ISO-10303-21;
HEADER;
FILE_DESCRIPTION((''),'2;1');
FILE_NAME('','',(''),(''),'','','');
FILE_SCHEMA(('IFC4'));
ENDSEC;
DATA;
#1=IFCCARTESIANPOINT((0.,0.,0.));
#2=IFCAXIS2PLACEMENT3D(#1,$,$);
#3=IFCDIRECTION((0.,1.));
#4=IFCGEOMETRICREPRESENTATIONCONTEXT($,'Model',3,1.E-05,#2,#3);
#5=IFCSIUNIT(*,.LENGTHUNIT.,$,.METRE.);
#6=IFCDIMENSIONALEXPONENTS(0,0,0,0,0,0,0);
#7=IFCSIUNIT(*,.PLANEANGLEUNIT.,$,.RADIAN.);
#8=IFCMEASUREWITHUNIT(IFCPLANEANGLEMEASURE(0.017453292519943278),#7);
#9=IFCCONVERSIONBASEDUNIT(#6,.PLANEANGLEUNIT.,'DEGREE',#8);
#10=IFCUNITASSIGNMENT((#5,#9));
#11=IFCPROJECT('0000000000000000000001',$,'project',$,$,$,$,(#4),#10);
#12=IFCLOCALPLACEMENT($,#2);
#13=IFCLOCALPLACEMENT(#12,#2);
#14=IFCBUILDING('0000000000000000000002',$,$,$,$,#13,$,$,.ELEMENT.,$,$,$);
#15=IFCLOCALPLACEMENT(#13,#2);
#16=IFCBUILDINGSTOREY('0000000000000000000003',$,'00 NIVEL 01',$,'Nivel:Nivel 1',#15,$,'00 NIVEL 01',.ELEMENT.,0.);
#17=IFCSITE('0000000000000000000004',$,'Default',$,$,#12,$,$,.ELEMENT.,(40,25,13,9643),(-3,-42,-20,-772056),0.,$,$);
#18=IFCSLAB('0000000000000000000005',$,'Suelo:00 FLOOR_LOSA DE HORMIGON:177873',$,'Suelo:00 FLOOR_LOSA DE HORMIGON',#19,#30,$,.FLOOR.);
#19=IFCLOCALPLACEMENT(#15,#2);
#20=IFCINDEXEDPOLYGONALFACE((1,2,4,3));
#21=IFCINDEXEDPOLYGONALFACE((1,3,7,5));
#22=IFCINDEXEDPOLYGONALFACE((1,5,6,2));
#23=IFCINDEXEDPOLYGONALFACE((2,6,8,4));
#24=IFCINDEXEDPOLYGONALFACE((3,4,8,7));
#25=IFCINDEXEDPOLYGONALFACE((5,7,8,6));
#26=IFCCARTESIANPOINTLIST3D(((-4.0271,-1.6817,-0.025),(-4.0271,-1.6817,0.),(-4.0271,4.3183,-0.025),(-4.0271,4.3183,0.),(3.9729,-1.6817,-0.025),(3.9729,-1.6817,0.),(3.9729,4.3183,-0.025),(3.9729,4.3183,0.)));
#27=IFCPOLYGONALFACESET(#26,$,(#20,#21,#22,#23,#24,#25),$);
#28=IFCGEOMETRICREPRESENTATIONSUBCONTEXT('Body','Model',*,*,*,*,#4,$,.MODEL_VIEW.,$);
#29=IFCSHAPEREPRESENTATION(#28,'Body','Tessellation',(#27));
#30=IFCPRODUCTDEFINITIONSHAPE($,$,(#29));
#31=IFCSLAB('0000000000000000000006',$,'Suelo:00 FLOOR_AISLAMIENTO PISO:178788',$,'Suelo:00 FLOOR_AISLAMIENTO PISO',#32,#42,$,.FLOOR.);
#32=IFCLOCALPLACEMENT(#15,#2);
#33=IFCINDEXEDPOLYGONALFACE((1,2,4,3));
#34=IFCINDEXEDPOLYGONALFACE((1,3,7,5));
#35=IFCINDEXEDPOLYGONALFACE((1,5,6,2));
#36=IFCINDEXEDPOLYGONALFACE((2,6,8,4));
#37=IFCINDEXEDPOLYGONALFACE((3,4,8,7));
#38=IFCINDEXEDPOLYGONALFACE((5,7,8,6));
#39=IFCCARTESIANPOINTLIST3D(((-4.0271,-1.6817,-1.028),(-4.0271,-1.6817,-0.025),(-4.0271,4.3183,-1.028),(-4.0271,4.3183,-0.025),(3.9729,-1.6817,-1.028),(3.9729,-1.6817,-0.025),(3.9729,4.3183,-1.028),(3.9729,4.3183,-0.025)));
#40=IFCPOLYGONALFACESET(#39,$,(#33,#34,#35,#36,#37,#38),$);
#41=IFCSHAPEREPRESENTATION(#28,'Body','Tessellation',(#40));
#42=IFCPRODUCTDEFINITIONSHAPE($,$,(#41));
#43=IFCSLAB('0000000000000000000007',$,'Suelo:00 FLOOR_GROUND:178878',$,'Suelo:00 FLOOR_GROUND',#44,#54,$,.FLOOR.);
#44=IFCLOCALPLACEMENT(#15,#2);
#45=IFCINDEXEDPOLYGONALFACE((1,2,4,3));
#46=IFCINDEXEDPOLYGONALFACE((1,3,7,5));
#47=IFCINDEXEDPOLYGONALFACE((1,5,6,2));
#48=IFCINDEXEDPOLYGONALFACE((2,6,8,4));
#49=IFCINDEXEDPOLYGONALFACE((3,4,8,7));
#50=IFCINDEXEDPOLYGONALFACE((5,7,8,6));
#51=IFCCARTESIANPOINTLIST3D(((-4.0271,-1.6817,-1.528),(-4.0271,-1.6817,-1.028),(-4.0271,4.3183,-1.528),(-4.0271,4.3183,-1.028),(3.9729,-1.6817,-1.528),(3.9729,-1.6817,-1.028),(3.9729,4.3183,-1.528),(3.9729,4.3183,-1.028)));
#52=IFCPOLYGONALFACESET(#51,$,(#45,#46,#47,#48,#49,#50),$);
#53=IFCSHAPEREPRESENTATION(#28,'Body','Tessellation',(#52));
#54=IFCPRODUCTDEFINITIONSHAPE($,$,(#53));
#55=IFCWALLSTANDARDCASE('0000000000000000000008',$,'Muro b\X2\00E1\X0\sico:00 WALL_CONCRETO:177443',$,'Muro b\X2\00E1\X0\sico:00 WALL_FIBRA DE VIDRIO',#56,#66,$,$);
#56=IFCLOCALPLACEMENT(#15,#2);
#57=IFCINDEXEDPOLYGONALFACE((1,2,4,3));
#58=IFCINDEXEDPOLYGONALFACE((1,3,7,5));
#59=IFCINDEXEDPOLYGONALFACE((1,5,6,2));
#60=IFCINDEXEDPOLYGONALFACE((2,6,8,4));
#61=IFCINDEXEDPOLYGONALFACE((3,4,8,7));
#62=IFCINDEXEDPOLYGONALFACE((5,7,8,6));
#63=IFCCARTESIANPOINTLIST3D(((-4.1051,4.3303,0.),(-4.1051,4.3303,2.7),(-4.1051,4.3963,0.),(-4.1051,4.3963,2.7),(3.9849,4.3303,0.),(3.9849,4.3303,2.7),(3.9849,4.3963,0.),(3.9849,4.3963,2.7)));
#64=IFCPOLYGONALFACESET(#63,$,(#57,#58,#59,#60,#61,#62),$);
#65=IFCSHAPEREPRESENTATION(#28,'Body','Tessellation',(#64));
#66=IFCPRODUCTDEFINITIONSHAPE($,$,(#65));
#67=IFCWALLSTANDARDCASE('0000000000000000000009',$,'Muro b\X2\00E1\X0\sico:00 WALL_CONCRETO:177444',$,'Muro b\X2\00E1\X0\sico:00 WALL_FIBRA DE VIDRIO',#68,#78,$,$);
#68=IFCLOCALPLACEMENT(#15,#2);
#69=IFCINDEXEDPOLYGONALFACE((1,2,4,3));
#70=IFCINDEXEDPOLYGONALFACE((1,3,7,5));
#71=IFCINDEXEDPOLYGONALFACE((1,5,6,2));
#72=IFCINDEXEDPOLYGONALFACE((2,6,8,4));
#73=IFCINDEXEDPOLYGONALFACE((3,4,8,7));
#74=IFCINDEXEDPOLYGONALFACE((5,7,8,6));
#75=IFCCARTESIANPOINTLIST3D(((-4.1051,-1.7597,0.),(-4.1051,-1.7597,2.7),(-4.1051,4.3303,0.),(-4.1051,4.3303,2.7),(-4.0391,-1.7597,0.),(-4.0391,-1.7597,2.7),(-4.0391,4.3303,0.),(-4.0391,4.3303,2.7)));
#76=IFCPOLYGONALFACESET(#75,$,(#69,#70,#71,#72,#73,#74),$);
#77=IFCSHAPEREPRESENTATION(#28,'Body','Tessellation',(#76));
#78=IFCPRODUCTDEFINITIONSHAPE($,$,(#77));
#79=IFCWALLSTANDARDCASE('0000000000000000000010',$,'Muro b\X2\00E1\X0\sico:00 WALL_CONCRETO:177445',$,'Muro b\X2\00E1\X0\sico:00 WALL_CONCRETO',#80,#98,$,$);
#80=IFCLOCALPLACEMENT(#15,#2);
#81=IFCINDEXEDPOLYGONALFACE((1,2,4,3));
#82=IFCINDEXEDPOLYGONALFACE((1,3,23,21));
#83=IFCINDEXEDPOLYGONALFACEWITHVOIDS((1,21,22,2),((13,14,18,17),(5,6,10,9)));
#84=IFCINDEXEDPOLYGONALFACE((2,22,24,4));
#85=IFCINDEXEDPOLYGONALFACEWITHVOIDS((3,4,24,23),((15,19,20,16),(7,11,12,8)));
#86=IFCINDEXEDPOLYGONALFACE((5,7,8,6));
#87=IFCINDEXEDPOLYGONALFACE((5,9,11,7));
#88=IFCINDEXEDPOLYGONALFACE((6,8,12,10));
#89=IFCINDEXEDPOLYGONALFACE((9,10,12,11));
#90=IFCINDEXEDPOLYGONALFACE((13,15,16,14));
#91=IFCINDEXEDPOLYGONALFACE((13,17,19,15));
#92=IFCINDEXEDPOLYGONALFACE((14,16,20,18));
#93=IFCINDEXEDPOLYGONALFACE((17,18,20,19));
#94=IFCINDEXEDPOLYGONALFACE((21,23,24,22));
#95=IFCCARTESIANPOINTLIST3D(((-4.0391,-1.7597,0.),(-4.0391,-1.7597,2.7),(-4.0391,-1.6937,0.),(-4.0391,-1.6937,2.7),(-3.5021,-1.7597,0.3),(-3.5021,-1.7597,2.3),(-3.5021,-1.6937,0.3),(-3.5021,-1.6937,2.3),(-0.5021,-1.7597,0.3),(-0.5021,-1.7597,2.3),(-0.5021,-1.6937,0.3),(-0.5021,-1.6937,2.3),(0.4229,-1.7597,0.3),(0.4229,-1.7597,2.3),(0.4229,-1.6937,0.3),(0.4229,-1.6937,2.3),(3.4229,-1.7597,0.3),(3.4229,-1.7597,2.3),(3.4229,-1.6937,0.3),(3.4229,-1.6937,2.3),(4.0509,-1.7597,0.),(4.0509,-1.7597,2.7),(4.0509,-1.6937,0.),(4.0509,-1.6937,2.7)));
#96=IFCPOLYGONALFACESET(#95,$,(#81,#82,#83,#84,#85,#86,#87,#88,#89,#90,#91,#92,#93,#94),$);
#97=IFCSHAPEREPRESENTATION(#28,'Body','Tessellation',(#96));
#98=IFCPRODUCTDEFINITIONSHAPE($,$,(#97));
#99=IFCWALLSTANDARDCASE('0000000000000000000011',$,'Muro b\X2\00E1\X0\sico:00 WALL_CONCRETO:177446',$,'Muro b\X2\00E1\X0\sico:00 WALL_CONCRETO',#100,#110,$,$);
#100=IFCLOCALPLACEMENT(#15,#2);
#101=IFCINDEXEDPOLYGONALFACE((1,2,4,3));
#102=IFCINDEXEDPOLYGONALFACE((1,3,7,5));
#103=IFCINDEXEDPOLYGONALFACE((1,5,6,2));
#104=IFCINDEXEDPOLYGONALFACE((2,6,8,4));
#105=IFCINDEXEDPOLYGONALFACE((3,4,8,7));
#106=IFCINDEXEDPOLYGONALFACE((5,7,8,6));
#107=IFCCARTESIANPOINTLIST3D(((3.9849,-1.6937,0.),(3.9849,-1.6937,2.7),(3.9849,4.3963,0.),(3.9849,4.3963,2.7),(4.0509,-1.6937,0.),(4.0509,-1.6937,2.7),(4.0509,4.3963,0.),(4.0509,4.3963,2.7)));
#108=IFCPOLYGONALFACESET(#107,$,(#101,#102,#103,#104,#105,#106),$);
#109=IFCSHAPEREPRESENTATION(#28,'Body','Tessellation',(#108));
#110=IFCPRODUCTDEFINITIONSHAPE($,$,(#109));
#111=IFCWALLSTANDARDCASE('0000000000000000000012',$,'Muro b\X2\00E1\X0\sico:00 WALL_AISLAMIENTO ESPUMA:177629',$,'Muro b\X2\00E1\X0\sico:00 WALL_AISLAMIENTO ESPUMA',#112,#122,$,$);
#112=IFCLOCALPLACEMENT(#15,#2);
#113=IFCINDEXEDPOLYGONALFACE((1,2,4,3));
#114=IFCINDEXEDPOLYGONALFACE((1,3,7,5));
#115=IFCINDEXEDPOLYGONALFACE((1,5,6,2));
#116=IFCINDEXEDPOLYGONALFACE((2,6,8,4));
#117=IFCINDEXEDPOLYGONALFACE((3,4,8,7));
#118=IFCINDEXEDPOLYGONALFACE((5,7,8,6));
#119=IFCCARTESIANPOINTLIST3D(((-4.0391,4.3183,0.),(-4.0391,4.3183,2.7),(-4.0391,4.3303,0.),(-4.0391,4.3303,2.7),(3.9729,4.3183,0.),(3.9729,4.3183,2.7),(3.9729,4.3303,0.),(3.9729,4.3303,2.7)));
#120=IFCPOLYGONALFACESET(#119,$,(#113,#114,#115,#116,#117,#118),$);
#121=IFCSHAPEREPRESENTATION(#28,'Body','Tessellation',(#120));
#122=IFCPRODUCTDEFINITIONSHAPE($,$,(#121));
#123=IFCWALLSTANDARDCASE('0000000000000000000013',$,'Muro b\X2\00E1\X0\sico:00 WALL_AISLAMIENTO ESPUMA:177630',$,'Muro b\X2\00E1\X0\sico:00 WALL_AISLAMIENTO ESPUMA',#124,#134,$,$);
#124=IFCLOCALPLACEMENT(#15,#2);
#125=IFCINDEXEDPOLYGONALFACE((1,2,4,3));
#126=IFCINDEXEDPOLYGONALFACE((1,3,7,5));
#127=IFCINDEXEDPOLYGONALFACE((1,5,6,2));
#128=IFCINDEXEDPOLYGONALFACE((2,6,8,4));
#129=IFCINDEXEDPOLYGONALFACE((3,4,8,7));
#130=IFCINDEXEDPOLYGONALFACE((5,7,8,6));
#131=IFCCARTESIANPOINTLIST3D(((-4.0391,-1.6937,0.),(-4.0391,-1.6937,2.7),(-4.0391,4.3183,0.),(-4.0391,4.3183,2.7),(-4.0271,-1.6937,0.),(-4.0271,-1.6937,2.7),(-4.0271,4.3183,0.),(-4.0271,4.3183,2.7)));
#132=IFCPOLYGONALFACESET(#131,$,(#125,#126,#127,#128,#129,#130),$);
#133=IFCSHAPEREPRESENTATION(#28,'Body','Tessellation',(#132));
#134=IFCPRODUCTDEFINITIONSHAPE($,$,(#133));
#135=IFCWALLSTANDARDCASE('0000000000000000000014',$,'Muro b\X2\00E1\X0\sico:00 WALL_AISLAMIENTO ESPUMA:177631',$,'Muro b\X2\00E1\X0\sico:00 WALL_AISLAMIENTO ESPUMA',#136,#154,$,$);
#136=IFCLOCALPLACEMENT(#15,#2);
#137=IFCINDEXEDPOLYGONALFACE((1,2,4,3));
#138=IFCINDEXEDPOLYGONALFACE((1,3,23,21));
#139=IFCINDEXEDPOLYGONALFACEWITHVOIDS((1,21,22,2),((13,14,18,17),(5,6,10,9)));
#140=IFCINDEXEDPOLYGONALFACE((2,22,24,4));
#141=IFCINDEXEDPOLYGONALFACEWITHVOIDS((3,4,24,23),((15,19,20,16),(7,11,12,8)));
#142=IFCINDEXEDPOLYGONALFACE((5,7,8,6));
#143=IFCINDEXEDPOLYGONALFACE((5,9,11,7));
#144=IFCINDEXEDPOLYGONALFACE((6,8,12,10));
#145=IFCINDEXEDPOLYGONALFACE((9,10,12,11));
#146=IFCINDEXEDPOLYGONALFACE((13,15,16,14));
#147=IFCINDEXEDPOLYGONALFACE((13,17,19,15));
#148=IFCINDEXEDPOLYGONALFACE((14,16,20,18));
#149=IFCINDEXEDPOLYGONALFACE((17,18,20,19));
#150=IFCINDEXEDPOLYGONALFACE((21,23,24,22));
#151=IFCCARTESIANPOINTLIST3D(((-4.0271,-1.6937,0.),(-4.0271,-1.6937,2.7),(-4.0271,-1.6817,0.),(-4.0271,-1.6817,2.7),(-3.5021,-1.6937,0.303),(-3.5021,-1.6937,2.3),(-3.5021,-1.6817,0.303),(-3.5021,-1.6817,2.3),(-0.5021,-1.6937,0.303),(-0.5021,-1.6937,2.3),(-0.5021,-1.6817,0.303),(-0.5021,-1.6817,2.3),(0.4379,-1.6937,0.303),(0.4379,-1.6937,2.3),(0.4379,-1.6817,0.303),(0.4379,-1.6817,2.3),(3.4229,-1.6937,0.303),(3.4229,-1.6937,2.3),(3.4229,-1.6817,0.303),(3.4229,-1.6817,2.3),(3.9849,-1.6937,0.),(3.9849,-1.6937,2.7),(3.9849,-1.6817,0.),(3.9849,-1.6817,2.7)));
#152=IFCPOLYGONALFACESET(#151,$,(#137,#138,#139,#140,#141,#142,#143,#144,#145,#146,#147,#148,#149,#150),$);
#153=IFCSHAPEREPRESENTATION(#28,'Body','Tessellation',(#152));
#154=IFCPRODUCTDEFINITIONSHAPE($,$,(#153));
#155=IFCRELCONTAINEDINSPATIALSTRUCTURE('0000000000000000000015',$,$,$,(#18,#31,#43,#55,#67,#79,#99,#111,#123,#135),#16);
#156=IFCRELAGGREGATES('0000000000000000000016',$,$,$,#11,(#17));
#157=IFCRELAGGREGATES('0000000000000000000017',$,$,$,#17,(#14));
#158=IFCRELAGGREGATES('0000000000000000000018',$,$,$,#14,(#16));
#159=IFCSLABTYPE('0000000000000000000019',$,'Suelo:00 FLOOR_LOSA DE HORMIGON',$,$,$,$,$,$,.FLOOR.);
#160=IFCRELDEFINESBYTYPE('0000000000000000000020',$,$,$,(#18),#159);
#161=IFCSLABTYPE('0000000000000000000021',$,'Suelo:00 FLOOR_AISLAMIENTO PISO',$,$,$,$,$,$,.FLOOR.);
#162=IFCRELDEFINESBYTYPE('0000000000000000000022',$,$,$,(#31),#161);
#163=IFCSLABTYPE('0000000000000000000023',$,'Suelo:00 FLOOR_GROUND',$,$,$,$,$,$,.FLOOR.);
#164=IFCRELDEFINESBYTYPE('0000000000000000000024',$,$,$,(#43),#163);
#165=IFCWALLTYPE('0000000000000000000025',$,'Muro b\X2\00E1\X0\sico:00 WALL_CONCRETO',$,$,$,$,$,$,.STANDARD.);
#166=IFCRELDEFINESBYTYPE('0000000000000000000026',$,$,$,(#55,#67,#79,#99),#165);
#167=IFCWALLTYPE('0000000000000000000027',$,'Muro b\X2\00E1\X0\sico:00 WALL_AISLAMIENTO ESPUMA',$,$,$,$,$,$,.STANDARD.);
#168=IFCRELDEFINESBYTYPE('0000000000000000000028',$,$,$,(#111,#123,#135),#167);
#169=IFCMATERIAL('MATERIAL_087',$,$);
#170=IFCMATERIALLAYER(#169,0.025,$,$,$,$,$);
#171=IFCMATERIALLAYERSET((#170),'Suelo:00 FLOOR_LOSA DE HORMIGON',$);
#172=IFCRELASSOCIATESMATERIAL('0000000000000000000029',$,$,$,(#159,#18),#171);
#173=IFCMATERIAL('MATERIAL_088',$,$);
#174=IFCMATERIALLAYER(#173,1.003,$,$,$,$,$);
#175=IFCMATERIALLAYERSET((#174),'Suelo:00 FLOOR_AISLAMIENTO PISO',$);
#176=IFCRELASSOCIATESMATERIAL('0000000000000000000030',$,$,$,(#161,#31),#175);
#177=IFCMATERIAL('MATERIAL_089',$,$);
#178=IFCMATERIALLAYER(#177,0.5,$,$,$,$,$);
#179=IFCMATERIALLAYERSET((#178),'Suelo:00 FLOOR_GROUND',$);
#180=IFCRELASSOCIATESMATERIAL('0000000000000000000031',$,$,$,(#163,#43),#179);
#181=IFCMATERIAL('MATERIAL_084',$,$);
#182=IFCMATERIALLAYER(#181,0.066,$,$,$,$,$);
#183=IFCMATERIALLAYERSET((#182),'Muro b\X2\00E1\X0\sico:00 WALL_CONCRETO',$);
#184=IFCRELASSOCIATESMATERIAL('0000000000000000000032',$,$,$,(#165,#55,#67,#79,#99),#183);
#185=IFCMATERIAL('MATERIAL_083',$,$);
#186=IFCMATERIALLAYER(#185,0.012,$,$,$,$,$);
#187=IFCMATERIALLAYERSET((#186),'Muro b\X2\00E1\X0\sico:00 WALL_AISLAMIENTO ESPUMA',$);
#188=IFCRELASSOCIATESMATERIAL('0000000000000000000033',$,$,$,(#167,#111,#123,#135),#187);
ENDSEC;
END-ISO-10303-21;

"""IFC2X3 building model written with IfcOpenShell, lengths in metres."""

from ifc_helpers import new_model, entity, si_unit, converted_unit, direction, frame, frame_2d, origin, origin_2d_with_axis, place, context, subcontext, project, spatial, rectangle, extrude, material, layer, layer_set, layer_usage, type_object, element, save


model = new_model("IFC2X3")

# Units and contexts
model_context = context("Model", 3, precision=1e-05, world=origin(), true_north=direction((0.0, 1.0)))
body_context = subcontext(model_context, "Body", "Model", "MODEL_VIEW")
ifc_project = project(units=[si_unit("LENGTHUNIT", "METRE"), converted_unit("PLANEANGLEUNIT", "DEGREE", entity("IfcPlaneAngleMeasure", 0.017453292519943278), si_unit("PLANEANGLEUNIT", "RADIAN"), dimensions=[0, 0, 0, 0, 0, 0, 0])], contexts=[model_context])

# Site, building, storey
site_placement = place(None, origin())
site = spatial("IfcSite", under=ifc_project, at=site_placement, Name="Default", CompositionType="ELEMENT", RefLatitude=(40, 25, 13, 9643), RefLongitude=(-3, -42, -20, -772056), RefElevation=0.0)
building_placement = place(site_placement, origin())
building = spatial("IfcBuilding", under=site, at=building_placement, CompositionType="ELEMENT")
storey_placement = place(building_placement, origin())
storey = spatial("IfcBuildingStorey", under=building, at=storey_placement, Name="00 NIVEL 01", ObjectType="Nivel:Nivel 1", LongName="00 NIVEL 01", CompositionType="ELEMENT", Elevation=0.0)

# Slabs
ifc_material_1 = material(Name="MATERIAL_087")
ifc_layer_1 = layer(ifc_material_1, 0.025)
ifc_layer_set_1 = layer_set([ifc_layer_1], Name="Suelo:00 FLOOR_LOSA DE HORMIGON")
ifc_layer_usage_1 = layer_usage(ifc_layer_set_1, "AXIS3", "POSITIVE", 0.0)
slab_type_1 = type_object("IfcSlabType", Name="Suelo:00 FLOOR_LOSA DE HORMIGON", PredefinedType="FLOOR", material=ifc_layer_set_1)
slab_1_placement = place(storey_placement, origin())
element("IfcSlab", 1, at=slab_1_placement, inside=storey, type_object=slab_type_1, material=ifc_layer_usage_1, Name="Suelo:00 FLOOR_LOSA DE HORMIGON:177873", ObjectType="Suelo:00 FLOOR_LOSA DE HORMIGON", PredefinedType="FLOOR", context=body_context, shape_type="SweptSolid", body=[
    extrude(rectangle(XDim=6.0, YDim=8.0, at=origin_2d_with_axis()), frame((-0.0271, 1.3183, 0.0), z_axis=(0.0, 0.0, -1.0), x_axis=(0.0, 1.0, 0.0)), (0.0, 0.0, 1.0), 0.025),
])
ifc_material_2 = material(Name="MATERIAL_088")
ifc_layer_2 = layer(ifc_material_2, 1.003)
ifc_layer_set_2 = layer_set([ifc_layer_2], Name="Suelo:00 FLOOR_AISLAMIENTO PISO")
ifc_layer_usage_2 = layer_usage(ifc_layer_set_2, "AXIS3", "POSITIVE", 0.0)
slab_type_2 = type_object("IfcSlabType", Name="Suelo:00 FLOOR_AISLAMIENTO PISO", PredefinedType="FLOOR", material=ifc_layer_set_2)
slab_2_placement = place(storey_placement, origin())
element("IfcSlab", 2, at=slab_2_placement, inside=storey, type_object=slab_type_2, material=ifc_layer_usage_2, Name="Suelo:00 FLOOR_AISLAMIENTO PISO:178788", ObjectType="Suelo:00 FLOOR_AISLAMIENTO PISO", PredefinedType="FLOOR", context=body_context, shape_type="SweptSolid", body=[
    extrude(rectangle(XDim=6.0, YDim=8.0, at=origin_2d_with_axis()), frame((-0.0271, 1.3183, -0.025), z_axis=(0.0, 0.0, -1.0), x_axis=(0.0, 1.0, 0.0)), (0.0, 0.0, 1.0), 1.003),
])
ifc_material_3 = material(Name="MATERIAL_089")
ifc_layer_3 = layer(ifc_material_3, 0.5)
ifc_layer_set_3 = layer_set([ifc_layer_3], Name="Suelo:00 FLOOR_GROUND")
ifc_layer_usage_3 = layer_usage(ifc_layer_set_3, "AXIS3", "POSITIVE", 0.0)
slab_type_3 = type_object("IfcSlabType", Name="Suelo:00 FLOOR_GROUND", PredefinedType="FLOOR", material=ifc_layer_set_3)
slab_3_placement = place(storey_placement, origin())
element("IfcSlab", 3, at=slab_3_placement, inside=storey, type_object=slab_type_3, material=ifc_layer_usage_3, Name="Suelo:00 FLOOR_GROUND:178878", ObjectType="Suelo:00 FLOOR_GROUND", PredefinedType="FLOOR", context=body_context, shape_type="SweptSolid", body=[
    extrude(rectangle(XDim=6.0, YDim=8.0, at=origin_2d_with_axis()), frame((-0.0271, 1.3183, -1.028), z_axis=(0.0, 0.0, -1.0), x_axis=(0.0, 1.0, 0.0)), (0.0, 0.0, 1.0), 0.5),
])

# Walls
ifc_material_4 = material(Name="MATERIAL_084")
ifc_layer_4 = layer(ifc_material_4, 0.066)
ifc_layer_set_4 = layer_set([ifc_layer_4], Name="Muro básico:00 WALL_CONCRETO")
ifc_layer_usage_4 = layer_usage(ifc_layer_set_4, "AXIS2", "NEGATIVE", 0.033)
wall_type_1 = type_object("IfcWallType", Name="Muro básico:00 WALL_CONCRETO", PredefinedType="STANDARD", material=ifc_layer_set_4)
wall_1_placement = place(storey_placement, frame((-4.1051, 4.3633, 0.0)))
element("IfcWallStandardCase", 4, at=wall_1_placement, inside=storey, type_object=wall_type_1, material=ifc_layer_usage_4, Name="Muro básico:00 WALL_CONCRETO:177443", ObjectType="Muro básico:00 WALL_FIBRA DE VIDRIO", context=body_context, shape_type="SweptSolid", body=[
    extrude(rectangle(XDim=8.09, YDim=0.066, at=frame_2d((4.045, 0.0), x_axis=(-1.0, 0.0))), origin(), (0.0, 0.0, 1.0), 2.7),
])
ifc_layer_usage_5 = layer_usage(ifc_layer_set_4, "AXIS2", "NEGATIVE", 0.033)
wall_2_placement = place(storey_placement, frame((-4.0721, -1.7597, 0.0), z_axis=(0.0, 0.0, 1.0), x_axis=(0.0, 1.0, 0.0)))
element("IfcWallStandardCase", 5, at=wall_2_placement, inside=storey, type_object=wall_type_1, material=ifc_layer_usage_5, Name="Muro básico:00 WALL_CONCRETO:177444", ObjectType="Muro básico:00 WALL_FIBRA DE VIDRIO", context=body_context, shape_type="SweptSolid", body=[
    extrude(rectangle(XDim=6.09, YDim=0.066, at=frame_2d((3.045, 0.0), x_axis=(-1.0, 0.0))), origin(), (0.0, 0.0, 1.0), 2.7),
])

# Wall, openings
ifc_layer_usage_6 = layer_usage(ifc_layer_set_4, "AXIS2", "NEGATIVE", 0.033)
wall_3_placement = place(storey_placement, frame((4.0509, -1.7267, 0.0), z_axis=(0.0, 0.0, 1.0), x_axis=(-1.0, 0.0, 0.0)))
wall_3 = element("IfcWallStandardCase", 6, at=wall_3_placement, inside=storey, type_object=wall_type_1, material=ifc_layer_usage_6, Name="Muro básico:00 WALL_CONCRETO:177445", ObjectType="Muro básico:00 WALL_CONCRETO", context=body_context, shape_type="SweptSolid", body=[
    extrude(rectangle(XDim=8.09, YDim=0.066, at=frame_2d((4.045, 0.0), x_axis=(-1.0, 0.0))), origin(), (0.0, 0.0, 1.0), 2.7),
])
opening_1_placement = place(wall_3_placement, frame((4.553, -0.033, 0.3)))
element("IfcOpeningElement", 7, at=opening_1_placement, cuts=wall_3, ObjectType="Opening", context=body_context, shape_type="SweptSolid", body=[
    extrude(rectangle(XDim=2.0, YDim=3.0, at=frame_2d((1.0, 1.5), x_axis=(1.0, 0.0))), frame((0.0, 0.0, 0.0), z_axis=(0.0, 1.0, 0.0), x_axis=(0.0, 0.0, 1.0)), (0.0, 0.0, 1.0), 0.066),
])
opening_2_placement = place(wall_3_placement, frame((3.628, 0.033, 0.3)))
element("IfcOpeningElement", 8, at=opening_2_placement, cuts=wall_3, ObjectType="Opening", context=body_context, shape_type="SweptSolid", body=[
    extrude(rectangle(XDim=2.0, YDim=3.0, at=frame_2d((1.0, 1.5), x_axis=(1.0, 0.0))), frame((0.0, 0.0, 0.0), z_axis=(0.0, -1.0, 0.0), x_axis=(0.0, 0.0, 1.0)), (0.0, 0.0, 1.0), 0.066),
])

# Walls
ifc_layer_usage_7 = layer_usage(ifc_layer_set_4, "AXIS2", "NEGATIVE", 0.033)
wall_4_placement = place(storey_placement, frame((4.0179, 4.3963, 0.0), z_axis=(0.0, 0.0, 1.0), x_axis=(0.0, -1.0, 0.0)))
element("IfcWallStandardCase", 9, at=wall_4_placement, inside=storey, type_object=wall_type_1, material=ifc_layer_usage_7, Name="Muro básico:00 WALL_CONCRETO:177446", ObjectType="Muro básico:00 WALL_CONCRETO", context=body_context, shape_type="SweptSolid", body=[
    extrude(rectangle(XDim=6.09, YDim=0.066, at=frame_2d((3.045, 0.0), x_axis=(-1.0, 0.0))), origin(), (0.0, 0.0, 1.0), 2.7),
])
ifc_material_5 = material(Name="MATERIAL_083")
ifc_layer_5 = layer(ifc_material_5, 0.012)
ifc_layer_set_5 = layer_set([ifc_layer_5], Name="Muro básico:00 WALL_AISLAMIENTO ESPUMA")
ifc_layer_usage_8 = layer_usage(ifc_layer_set_5, "AXIS2", "NEGATIVE", 0.006)
wall_type_2 = type_object("IfcWallType", Name="Muro básico:00 WALL_AISLAMIENTO ESPUMA", PredefinedType="STANDARD", material=ifc_layer_set_5)
wall_5_placement = place(storey_placement, frame((-4.0391, 4.3243, 0.0)))
element("IfcWallStandardCase", 10, at=wall_5_placement, inside=storey, type_object=wall_type_2, material=ifc_layer_usage_8, Name="Muro básico:00 WALL_AISLAMIENTO ESPUMA:177629", ObjectType="Muro básico:00 WALL_AISLAMIENTO ESPUMA", context=body_context, shape_type="SweptSolid", body=[
    extrude(rectangle(XDim=8.012, YDim=0.012, at=frame_2d((4.006, 0.0), x_axis=(-1.0, 0.0))), origin(), (0.0, 0.0, 1.0), 2.7),
])
ifc_layer_usage_9 = layer_usage(ifc_layer_set_5, "AXIS2", "NEGATIVE", 0.006)
wall_6_placement = place(storey_placement, frame((-4.0331, -1.6937, 0.0), z_axis=(0.0, 0.0, 1.0), x_axis=(0.0, 1.0, 0.0)))
element("IfcWallStandardCase", 11, at=wall_6_placement, inside=storey, type_object=wall_type_2, material=ifc_layer_usage_9, Name="Muro básico:00 WALL_AISLAMIENTO ESPUMA:177630", ObjectType="Muro básico:00 WALL_AISLAMIENTO ESPUMA", context=body_context, shape_type="SweptSolid", body=[
    extrude(rectangle(XDim=6.012, YDim=0.012, at=frame_2d((3.006, 0.0), x_axis=(-1.0, 0.0))), origin(), (0.0, 0.0, 1.0), 2.7),
])

# Wall, openings
ifc_layer_usage_10 = layer_usage(ifc_layer_set_5, "AXIS2", "NEGATIVE", 0.006)
wall_7_placement = place(storey_placement, frame((3.9849, -1.6877, 0.0), z_axis=(0.0, 0.0, 1.0), x_axis=(-1.0, 0.0, 0.0)))
wall_7 = element("IfcWallStandardCase", 12, at=wall_7_placement, inside=storey, type_object=wall_type_2, material=ifc_layer_usage_10, Name="Muro básico:00 WALL_AISLAMIENTO ESPUMA:177631", ObjectType="Muro básico:00 WALL_AISLAMIENTO ESPUMA", context=body_context, shape_type="SweptSolid", body=[
    extrude(rectangle(XDim=8.012, YDim=0.012, at=frame_2d((4.006, 0.0), x_axis=(-1.0, 0.0))), origin(), (0.0, 0.0, 1.0), 2.7),
])
opening_3_placement = place(wall_7_placement, origin())
element("IfcOpeningElement", 13, at=opening_3_placement, cuts=wall_7, ObjectType="Opening", context=body_context, shape_type="SweptSolid", body=[
    extrude(rectangle(XDim=1.997, YDim=2.985, at=frame_2d((0.0, 0.0), x_axis=(1.0, 0.0))), frame((2.0545, 0.006, 1.3015), z_axis=(0.0, -1.0, 0.0), x_axis=(0.0, 0.0, 1.0)), (0.0, 0.0, 1.0), 0.012),
])
opening_4_placement = place(wall_7_placement, origin())
element("IfcOpeningElement", 14, at=opening_4_placement, cuts=wall_7, ObjectType="Opening", context=body_context, shape_type="SweptSolid", body=[
    extrude(rectangle(XDim=1.997, YDim=3.0, at=frame_2d((0.0, 0.0), x_axis=(1.0, 0.0))), frame((5.987, 0.006, 1.3015), z_axis=(0.0, -1.0, 0.0), x_axis=(0.0, 0.0, -1.0)), (0.0, 0.0, 1.0), 0.012),
])

save(model, "model.ifc")
